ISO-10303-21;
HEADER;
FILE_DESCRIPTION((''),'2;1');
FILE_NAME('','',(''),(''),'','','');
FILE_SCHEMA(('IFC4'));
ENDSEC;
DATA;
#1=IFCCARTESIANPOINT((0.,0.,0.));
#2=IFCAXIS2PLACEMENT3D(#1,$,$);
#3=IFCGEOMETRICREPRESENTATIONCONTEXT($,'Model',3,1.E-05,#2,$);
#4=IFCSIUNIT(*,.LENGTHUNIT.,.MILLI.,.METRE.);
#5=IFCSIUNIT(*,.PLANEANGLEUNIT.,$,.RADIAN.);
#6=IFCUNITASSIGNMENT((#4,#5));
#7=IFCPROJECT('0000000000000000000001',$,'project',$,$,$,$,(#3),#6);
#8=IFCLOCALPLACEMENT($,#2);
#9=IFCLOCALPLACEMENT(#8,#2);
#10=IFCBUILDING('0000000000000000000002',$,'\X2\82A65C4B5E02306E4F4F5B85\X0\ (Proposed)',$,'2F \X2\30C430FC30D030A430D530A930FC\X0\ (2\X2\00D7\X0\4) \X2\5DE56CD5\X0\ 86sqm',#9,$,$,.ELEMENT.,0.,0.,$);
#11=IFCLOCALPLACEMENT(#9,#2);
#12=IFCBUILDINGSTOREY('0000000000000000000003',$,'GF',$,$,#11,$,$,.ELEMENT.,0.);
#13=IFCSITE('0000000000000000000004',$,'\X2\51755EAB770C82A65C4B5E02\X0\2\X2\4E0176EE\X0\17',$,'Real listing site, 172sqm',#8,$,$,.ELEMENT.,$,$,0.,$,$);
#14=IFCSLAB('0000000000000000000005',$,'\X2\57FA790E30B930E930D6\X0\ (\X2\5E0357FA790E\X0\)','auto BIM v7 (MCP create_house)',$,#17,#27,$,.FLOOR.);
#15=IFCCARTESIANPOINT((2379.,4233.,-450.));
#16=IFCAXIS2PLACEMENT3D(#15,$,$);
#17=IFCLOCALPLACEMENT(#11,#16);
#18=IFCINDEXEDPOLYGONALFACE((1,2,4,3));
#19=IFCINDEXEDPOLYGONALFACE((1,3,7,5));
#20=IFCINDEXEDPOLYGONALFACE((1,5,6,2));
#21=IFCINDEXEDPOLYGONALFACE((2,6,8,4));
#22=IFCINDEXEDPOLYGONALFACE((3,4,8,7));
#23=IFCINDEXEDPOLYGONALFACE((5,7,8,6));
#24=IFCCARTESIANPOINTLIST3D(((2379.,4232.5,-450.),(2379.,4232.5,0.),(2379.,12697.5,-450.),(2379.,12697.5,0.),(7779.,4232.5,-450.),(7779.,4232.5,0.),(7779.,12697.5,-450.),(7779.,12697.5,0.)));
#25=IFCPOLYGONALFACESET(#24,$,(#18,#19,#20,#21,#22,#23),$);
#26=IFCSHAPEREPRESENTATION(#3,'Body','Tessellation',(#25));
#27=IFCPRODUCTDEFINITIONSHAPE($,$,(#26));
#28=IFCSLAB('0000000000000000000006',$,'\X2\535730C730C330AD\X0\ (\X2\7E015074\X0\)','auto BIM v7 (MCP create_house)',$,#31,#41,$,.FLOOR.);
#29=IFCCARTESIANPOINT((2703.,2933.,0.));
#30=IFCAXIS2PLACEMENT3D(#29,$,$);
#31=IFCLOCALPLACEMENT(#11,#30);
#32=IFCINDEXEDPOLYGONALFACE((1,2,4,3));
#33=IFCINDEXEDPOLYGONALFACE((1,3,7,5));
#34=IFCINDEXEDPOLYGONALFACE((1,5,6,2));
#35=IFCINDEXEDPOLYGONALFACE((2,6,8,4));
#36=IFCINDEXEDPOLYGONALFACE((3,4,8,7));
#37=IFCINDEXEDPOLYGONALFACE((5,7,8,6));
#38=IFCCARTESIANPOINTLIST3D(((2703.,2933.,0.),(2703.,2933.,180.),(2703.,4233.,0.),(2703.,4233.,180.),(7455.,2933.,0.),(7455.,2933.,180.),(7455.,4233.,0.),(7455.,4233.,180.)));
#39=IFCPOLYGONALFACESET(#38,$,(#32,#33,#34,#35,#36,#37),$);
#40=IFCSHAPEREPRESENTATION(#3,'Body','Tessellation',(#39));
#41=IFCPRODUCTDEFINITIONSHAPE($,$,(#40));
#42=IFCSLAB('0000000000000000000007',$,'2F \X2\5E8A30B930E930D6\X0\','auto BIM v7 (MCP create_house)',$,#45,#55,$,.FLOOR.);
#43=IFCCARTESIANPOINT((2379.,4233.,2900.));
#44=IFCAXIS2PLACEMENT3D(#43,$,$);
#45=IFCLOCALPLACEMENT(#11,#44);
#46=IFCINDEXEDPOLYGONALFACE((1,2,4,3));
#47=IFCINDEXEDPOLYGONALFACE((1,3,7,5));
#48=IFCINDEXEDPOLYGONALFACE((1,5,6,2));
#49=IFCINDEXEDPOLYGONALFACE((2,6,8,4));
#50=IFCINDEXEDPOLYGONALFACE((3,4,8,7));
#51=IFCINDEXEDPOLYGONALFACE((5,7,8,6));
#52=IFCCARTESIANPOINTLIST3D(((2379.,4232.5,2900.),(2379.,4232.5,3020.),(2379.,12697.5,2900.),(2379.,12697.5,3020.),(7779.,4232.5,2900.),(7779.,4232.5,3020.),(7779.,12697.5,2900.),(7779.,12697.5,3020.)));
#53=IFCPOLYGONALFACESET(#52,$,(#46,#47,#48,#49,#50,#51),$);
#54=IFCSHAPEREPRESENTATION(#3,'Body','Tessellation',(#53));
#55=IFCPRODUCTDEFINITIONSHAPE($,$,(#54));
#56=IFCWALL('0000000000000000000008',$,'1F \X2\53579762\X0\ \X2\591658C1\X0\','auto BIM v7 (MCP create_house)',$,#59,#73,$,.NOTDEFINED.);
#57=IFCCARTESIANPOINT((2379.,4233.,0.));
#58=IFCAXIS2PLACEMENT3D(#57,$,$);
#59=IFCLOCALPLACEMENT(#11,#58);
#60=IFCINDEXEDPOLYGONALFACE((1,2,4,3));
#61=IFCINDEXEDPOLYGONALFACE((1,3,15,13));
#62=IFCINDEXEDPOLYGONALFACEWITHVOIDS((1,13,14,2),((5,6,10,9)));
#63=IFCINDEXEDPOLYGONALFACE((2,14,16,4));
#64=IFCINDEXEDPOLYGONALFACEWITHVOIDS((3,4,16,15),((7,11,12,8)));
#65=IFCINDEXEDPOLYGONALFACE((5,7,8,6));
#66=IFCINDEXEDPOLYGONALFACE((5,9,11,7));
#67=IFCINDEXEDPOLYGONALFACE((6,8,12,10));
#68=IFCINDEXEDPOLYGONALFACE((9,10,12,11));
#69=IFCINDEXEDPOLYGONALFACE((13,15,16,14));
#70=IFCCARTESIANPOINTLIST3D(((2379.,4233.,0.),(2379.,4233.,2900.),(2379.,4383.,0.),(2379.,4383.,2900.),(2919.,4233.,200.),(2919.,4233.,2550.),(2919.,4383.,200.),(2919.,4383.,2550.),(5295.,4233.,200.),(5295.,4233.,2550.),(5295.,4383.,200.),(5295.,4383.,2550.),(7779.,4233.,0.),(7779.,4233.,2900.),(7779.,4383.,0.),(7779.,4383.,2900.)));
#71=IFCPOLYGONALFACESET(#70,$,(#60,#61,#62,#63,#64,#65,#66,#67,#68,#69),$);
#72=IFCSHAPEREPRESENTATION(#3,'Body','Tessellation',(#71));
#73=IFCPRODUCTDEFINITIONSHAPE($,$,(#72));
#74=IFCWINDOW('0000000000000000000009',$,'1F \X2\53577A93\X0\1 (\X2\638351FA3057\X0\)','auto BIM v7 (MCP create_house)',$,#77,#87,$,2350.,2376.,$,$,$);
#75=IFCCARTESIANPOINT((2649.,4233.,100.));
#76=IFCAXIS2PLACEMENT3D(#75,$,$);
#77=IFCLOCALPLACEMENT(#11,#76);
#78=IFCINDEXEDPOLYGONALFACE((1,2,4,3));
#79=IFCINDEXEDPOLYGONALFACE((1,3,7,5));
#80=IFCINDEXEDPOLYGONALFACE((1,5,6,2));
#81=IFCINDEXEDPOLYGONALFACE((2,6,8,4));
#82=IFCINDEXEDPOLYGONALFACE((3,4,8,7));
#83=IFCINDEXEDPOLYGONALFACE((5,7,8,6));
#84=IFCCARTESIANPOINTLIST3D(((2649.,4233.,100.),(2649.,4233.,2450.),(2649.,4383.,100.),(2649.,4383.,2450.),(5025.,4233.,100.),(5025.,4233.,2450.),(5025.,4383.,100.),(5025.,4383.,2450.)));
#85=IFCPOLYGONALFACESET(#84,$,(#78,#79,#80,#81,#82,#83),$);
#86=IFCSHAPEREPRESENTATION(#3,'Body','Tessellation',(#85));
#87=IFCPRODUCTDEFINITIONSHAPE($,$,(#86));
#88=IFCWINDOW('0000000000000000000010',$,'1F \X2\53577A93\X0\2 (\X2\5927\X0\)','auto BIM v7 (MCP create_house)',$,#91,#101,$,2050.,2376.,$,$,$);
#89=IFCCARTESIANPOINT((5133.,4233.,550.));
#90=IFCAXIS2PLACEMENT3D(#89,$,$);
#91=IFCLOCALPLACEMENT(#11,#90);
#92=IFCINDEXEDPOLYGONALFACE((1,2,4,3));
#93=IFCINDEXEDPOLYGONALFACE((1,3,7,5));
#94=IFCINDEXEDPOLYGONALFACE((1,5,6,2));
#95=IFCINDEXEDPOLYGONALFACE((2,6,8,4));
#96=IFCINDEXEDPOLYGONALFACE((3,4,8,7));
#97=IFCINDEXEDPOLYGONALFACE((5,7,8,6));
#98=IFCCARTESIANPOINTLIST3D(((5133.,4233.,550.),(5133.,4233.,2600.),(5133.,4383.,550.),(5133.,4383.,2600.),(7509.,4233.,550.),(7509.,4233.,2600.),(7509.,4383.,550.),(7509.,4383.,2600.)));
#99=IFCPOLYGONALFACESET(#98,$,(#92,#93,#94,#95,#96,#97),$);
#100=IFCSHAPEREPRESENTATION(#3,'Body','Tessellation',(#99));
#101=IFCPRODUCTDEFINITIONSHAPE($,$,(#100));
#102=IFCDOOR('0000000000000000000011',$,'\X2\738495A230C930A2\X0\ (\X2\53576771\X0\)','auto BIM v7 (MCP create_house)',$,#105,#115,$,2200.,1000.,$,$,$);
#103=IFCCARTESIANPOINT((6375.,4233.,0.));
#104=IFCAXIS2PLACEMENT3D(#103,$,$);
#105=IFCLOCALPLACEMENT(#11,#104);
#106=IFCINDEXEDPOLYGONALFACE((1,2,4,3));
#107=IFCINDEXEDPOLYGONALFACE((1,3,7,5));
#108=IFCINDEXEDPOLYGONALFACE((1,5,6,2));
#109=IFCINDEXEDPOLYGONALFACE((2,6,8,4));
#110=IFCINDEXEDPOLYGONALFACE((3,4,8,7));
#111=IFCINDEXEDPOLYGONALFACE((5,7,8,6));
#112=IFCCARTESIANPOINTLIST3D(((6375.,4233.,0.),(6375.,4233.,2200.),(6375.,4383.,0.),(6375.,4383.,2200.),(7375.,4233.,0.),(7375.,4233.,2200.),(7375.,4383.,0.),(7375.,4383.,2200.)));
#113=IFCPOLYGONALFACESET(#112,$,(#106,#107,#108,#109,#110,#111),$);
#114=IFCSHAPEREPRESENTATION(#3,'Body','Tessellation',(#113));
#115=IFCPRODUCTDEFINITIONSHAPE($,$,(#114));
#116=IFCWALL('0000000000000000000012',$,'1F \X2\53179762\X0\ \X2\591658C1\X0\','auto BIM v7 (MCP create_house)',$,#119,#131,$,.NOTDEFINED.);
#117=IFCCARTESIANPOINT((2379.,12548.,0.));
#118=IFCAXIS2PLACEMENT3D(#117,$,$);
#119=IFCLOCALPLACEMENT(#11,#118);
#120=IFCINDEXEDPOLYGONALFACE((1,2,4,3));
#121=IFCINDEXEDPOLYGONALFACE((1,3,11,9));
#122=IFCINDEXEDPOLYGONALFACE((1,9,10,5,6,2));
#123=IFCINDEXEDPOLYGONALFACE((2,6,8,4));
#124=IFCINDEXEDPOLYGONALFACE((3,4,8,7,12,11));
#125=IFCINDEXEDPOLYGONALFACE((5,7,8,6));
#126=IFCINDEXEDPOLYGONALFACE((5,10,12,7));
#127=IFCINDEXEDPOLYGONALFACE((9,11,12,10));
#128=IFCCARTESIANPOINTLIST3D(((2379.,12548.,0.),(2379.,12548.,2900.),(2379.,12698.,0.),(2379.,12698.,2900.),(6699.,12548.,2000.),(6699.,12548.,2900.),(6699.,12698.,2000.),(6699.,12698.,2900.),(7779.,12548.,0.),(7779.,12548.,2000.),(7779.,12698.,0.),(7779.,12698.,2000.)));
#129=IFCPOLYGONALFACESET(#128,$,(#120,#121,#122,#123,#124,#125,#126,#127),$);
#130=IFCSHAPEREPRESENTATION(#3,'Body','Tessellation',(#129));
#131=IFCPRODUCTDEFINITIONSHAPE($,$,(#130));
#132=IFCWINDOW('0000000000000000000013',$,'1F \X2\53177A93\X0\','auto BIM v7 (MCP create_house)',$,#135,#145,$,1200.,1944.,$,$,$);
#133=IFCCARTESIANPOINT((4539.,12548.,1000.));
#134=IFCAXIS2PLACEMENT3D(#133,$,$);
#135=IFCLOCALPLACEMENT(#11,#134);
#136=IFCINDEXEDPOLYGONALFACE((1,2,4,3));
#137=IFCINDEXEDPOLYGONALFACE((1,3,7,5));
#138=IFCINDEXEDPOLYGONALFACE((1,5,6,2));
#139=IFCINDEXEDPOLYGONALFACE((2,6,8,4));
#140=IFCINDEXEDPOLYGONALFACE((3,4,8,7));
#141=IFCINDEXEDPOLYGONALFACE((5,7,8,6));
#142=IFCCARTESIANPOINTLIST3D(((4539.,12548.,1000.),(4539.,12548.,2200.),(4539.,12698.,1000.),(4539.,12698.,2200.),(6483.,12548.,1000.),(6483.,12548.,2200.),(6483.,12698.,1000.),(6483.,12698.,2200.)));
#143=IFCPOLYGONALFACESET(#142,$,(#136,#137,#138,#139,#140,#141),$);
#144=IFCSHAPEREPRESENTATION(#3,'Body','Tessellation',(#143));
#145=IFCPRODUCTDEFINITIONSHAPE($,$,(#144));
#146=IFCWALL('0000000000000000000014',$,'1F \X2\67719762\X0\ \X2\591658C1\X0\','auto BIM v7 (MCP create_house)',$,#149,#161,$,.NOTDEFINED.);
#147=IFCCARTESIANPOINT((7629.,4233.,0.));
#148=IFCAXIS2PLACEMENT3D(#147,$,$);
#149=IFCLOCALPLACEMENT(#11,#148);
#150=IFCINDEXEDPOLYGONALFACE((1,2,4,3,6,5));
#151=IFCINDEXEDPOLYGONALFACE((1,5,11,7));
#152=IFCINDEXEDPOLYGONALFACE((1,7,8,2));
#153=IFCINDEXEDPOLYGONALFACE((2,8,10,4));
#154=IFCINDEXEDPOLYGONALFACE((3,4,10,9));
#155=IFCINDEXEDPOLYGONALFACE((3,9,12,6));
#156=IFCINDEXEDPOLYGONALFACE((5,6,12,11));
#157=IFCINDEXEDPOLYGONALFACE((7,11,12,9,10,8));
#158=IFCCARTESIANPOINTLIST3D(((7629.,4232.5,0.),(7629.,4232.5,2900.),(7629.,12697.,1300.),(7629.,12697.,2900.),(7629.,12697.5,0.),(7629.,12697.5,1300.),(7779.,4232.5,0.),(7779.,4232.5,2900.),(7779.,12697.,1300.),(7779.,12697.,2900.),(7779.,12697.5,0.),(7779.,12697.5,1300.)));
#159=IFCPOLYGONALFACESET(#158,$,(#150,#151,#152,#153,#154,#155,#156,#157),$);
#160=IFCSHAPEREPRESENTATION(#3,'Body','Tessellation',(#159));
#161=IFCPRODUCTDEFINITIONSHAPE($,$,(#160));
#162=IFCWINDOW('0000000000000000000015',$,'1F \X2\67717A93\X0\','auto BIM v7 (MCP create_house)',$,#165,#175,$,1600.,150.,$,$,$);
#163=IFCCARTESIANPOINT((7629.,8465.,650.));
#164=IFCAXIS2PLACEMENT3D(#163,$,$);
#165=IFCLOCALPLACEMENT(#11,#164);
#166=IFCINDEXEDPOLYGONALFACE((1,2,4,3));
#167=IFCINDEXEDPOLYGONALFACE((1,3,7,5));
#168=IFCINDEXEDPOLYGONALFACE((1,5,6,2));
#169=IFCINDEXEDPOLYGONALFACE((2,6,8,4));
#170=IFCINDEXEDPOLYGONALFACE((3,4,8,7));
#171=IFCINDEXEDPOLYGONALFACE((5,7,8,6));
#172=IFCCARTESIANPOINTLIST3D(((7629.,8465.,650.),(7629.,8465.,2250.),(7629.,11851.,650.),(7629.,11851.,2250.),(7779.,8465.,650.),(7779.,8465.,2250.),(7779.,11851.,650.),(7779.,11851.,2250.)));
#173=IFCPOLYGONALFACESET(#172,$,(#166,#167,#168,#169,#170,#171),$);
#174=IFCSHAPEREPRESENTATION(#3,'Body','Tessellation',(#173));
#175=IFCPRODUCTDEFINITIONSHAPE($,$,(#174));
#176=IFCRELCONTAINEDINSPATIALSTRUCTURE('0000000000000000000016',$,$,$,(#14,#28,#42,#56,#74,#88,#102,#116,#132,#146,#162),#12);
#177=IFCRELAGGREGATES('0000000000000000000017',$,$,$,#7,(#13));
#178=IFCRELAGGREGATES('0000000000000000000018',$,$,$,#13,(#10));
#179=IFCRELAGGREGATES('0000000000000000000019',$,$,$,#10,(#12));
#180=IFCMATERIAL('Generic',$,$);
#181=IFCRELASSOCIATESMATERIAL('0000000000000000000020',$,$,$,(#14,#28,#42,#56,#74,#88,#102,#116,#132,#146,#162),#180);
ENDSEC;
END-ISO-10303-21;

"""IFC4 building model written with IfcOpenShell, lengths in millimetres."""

from ifc_helpers import new_model, si_unit, frame, frame_2d, origin, place, context, project, spatial, rectangle, extrude, material, element, fill, save


model = new_model("IFC4")

# Units and contexts
model_context = context("Model", 3, precision=1e-05, world=origin())
ifc_project = project(units=[si_unit("LENGTHUNIT", "METRE", prefix="MILLI"), si_unit("PLANEANGLEUNIT", "RADIAN")], contexts=[model_context])

# Site, building, storey
site_placement = place(None, origin())
site = spatial("IfcSite", under=ifc_project, at=site_placement, Name="兵庫県芦屋市2丁目17", ObjectType="Real listing site, 172sqm", CompositionType="ELEMENT", RefElevation=0.0)
building_placement = place(site_placement, origin())
building = spatial("IfcBuilding", under=site, at=building_placement, Name="芦屋市の住宅 (Proposed)", ObjectType="2F ツーバイフォー (2×4) 工法 86sqm", CompositionType="ELEMENT", ElevationOfRefHeight=0.0, ElevationOfTerrain=0.0)
storey_placement = place(building_placement, origin())
storey = spatial("IfcBuildingStorey", under=building, at=storey_placement, Name="GF", CompositionType="ELEMENT", Elevation=0.0)

# Slabs
ifc_material = material(Name="Generic")
slab_1_placement = place(storey_placement, frame((2379.0, 4233.0, -450.0)))
element("IfcSlab", 1, at=slab_1_placement, inside=storey, material=ifc_material, Name="基礎スラブ (布基礎)", Description="auto BIM v7 (MCP create_house)", PredefinedType="FLOOR", context=model_context, shape_type="SweptSolid", body=[
    extrude(rectangle(XDim=5400.0, YDim=8465.0, at=frame_2d((2700.0, 4232.0))), frame((2379.0, 4233.0, -450.0)), (0.0, 0.0, 1.0), 450.0),
])
slab_2_placement = place(storey_placement, frame((2703.0, 2933.0, 0.0)))
element("IfcSlab", 2, at=slab_2_placement, inside=storey, material=ifc_material, Name="南デッキ (縁側)", Description="auto BIM v7 (MCP create_house)", PredefinedType="FLOOR", context=model_context, shape_type="SweptSolid", body=[
    extrude(rectangle(XDim=4752.0, YDim=1300.0, at=frame_2d((2376.0, 650.0))), frame((2703.0, 2933.0, 0.0)), (0.0, 0.0, 1.0), 180.0),
])
slab_3_placement = place(storey_placement, frame((2379.0, 4233.0, 2900.0)))
element("IfcSlab", 3, at=slab_3_placement, inside=storey, material=ifc_material, Name="2F 床スラブ", Description="auto BIM v7 (MCP create_house)", PredefinedType="FLOOR", context=model_context, shape_type="SweptSolid", body=[
    extrude(rectangle(XDim=5400.0, YDim=8465.0, at=frame_2d((2700.0, 4232.0))), frame((2379.0, 4233.0, 2900.0)), (0.0, 0.0, 1.0), 120.0),
])

# Wall, openings, windows, door
wall_1_placement = place(storey_placement, frame((2379.0, 4233.0, 0.0)))
wall_1 = element("IfcWall", 4, at=wall_1_placement, inside=storey, material=ifc_material, Name="1F 南面 外壁", Description="auto BIM v7 (MCP create_house)", PredefinedType="NOTDEFINED", context=model_context, shape_type="SweptSolid", body=[
    extrude(rectangle(XDim=5400.0, YDim=150.0, at=frame_2d((2700.0, 75.0))), frame((2379.0, 4233.0, 0.0)), (0.0, 0.0, 1.0), 2900.0),
])
opening_1_placement = place(storey_placement, frame((2649.0, 4233.0, 100.0)))
opening_1 = element("IfcOpeningElement", 5, at=opening_1_placement, cuts=wall_1, PredefinedType="NOTDEFINED", context=model_context, shape_type="SweptSolid", body=[
    extrude(rectangle(XDim=2376.0, YDim=150.0, at=frame_2d((1188.0, 75.0))), frame((2649.0, 4233.0, 100.0)), (0.0, 0.0, 1.0), 2350.0),
])
opening_2_placement = place(storey_placement, frame((5133.0, 4233.0, 550.0)))
opening_2 = element("IfcOpeningElement", 6, at=opening_2_placement, cuts=wall_1, PredefinedType="NOTDEFINED", context=model_context, shape_type="SweptSolid", body=[
    extrude(rectangle(XDim=2376.0, YDim=150.0, at=frame_2d((1188.0, 75.0))), frame((5133.0, 4233.0, 550.0)), (0.0, 0.0, 1.0), 2050.0),
])
opening_3_placement = place(storey_placement, frame((6375.0, 4233.0, 0.0)))
opening_3 = element("IfcOpeningElement", 7, at=opening_3_placement, cuts=wall_1, PredefinedType="NOTDEFINED", context=model_context, shape_type="SweptSolid", body=[
    extrude(rectangle(XDim=1000.0, YDim=150.0, at=frame_2d((500.0, 75.0))), frame((6375.0, 4233.0, 0.0)), (0.0, 0.0, 1.0), 2200.0),
])
window_1_placement = place(storey_placement, frame((2649.0, 4233.0, 100.0)))
window_1 = element("IfcWindow", 8, at=window_1_placement, inside=storey, material=ifc_material, Name="1F 南窓1 (掃出し)", Description="auto BIM v7 (MCP create_house)", OverallHeight=2350.0, OverallWidth=2376.0, context=model_context, shape_type="SweptSolid", body=[
    extrude(rectangle(XDim=2376.0, YDim=150.0, at=frame_2d((1188.0, 75.0))), frame((2649.0, 4233.0, 100.0)), (0.0, 0.0, 1.0), 2350.0),
])
fill(opening_1, window_1)
window_2_placement = place(storey_placement, frame((5133.0, 4233.0, 550.0)))
window_2 = element("IfcWindow", 9, at=window_2_placement, inside=storey, material=ifc_material, Name="1F 南窓2 (大)", Description="auto BIM v7 (MCP create_house)", OverallHeight=2050.0, OverallWidth=2376.0, context=model_context, shape_type="SweptSolid", body=[
    extrude(rectangle(XDim=2376.0, YDim=150.0, at=frame_2d((1188.0, 75.0))), frame((5133.0, 4233.0, 550.0)), (0.0, 0.0, 1.0), 2050.0),
])
fill(opening_2, window_2)
door_placement = place(storey_placement, frame((6375.0, 4233.0, 0.0)))
door = element("IfcDoor", 10, at=door_placement, inside=storey, material=ifc_material, Name="玄関ドア (南東)", Description="auto BIM v7 (MCP create_house)", OverallHeight=2200.0, OverallWidth=1000.0, context=model_context, shape_type="SweptSolid", body=[
    extrude(rectangle(XDim=1000.0, YDim=150.0, at=frame_2d((500.0, 75.0))), frame((6375.0, 4233.0, 0.0)), (0.0, 0.0, 1.0), 2200.0),
])
fill(opening_3, door)

# Walls, openings, windows
wall_2_placement = place(storey_placement, frame((2379.0, 12548.0, 0.0)))
wall_2 = element("IfcWall", 11, at=wall_2_placement, inside=storey, material=ifc_material, Name="1F 北面 外壁", Description="auto BIM v7 (MCP create_house)", PredefinedType="NOTDEFINED", context=model_context, shape_type="SweptSolid", body=[
    extrude(rectangle(XDim=5400.0, YDim=150.0, at=frame_2d((2700.0, 75.0))), frame((2379.0, 12548.0, 0.0)), (0.0, 0.0, 1.0), 2900.0),
])
opening_4_placement = place(storey_placement, frame((4539.0, 12548.0, 1000.0)))
opening_4 = element("IfcOpeningElement", 12, at=opening_4_placement, cuts=wall_2, PredefinedType="NOTDEFINED", context=model_context, shape_type="SweptSolid", body=[
    extrude(rectangle(XDim=1944.0, YDim=150.0, at=frame_2d((972.0, 75.0))), frame((4539.0, 12548.0, 1000.0)), (0.0, 0.0, 1.0), 1200.0),
])
window_3_placement = place(storey_placement, frame((4539.0, 12548.0, 1000.0)))
window_3 = element("IfcWindow", 13, at=window_3_placement, inside=storey, material=ifc_material, Name="1F 北窓", Description="auto BIM v7 (MCP create_house)", OverallHeight=1200.0, OverallWidth=1944.0, context=model_context, shape_type="SweptSolid", body=[
    extrude(rectangle(XDim=1944.0, YDim=150.0, at=frame_2d((972.0, 75.0))), frame((4539.0, 12548.0, 1000.0)), (0.0, 0.0, 1.0), 1200.0),
])
fill(opening_4, window_3)
wall_3_placement = place(storey_placement, frame((7629.0, 4233.0, 0.0)))
wall_3 = element("IfcWall", 14, at=wall_3_placement, inside=storey, material=ifc_material, Name="1F 東面 外壁", Description="auto BIM v7 (MCP create_house)", PredefinedType="NOTDEFINED", context=model_context, shape_type="SweptSolid", body=[
    extrude(rectangle(XDim=150.0, YDim=8465.0, at=frame_2d((75.0, 4232.0))), frame((7629.0, 4233.0, 0.0)), (0.0, 0.0, 1.0), 2900.0),
])
opening_5_placement = place(storey_placement, frame((7629.0, 8465.0, 650.0)))
opening_5 = element("IfcOpeningElement", 15, at=opening_5_placement, cuts=wall_3, PredefinedType="NOTDEFINED", context=model_context, shape_type="SweptSolid", body=[
    extrude(rectangle(XDim=150.0, YDim=3386.0, at=frame_2d((75.0, 1693.0))), frame((7629.0, 8465.0, 650.0)), (0.0, 0.0, 1.0), 1600.0),
])
window_4_placement = place(storey_placement, frame((7629.0, 8465.0, 650.0)))
window_4 = element("IfcWindow", 16, at=window_4_placement, inside=storey, material=ifc_material, Name="1F 東窓", Description="auto BIM v7 (MCP create_house)", OverallHeight=1600.0, OverallWidth=150.0, context=model_context, shape_type="SweptSolid", body=[
    extrude(rectangle(XDim=150.0, YDim=3386.0, at=frame_2d((75.0, 1693.0))), frame((7629.0, 8465.0, 650.0)), (0.0, 0.0, 1.0), 1600.0),
])
fill(opening_5, window_4)

save(model, "model.ifc")
